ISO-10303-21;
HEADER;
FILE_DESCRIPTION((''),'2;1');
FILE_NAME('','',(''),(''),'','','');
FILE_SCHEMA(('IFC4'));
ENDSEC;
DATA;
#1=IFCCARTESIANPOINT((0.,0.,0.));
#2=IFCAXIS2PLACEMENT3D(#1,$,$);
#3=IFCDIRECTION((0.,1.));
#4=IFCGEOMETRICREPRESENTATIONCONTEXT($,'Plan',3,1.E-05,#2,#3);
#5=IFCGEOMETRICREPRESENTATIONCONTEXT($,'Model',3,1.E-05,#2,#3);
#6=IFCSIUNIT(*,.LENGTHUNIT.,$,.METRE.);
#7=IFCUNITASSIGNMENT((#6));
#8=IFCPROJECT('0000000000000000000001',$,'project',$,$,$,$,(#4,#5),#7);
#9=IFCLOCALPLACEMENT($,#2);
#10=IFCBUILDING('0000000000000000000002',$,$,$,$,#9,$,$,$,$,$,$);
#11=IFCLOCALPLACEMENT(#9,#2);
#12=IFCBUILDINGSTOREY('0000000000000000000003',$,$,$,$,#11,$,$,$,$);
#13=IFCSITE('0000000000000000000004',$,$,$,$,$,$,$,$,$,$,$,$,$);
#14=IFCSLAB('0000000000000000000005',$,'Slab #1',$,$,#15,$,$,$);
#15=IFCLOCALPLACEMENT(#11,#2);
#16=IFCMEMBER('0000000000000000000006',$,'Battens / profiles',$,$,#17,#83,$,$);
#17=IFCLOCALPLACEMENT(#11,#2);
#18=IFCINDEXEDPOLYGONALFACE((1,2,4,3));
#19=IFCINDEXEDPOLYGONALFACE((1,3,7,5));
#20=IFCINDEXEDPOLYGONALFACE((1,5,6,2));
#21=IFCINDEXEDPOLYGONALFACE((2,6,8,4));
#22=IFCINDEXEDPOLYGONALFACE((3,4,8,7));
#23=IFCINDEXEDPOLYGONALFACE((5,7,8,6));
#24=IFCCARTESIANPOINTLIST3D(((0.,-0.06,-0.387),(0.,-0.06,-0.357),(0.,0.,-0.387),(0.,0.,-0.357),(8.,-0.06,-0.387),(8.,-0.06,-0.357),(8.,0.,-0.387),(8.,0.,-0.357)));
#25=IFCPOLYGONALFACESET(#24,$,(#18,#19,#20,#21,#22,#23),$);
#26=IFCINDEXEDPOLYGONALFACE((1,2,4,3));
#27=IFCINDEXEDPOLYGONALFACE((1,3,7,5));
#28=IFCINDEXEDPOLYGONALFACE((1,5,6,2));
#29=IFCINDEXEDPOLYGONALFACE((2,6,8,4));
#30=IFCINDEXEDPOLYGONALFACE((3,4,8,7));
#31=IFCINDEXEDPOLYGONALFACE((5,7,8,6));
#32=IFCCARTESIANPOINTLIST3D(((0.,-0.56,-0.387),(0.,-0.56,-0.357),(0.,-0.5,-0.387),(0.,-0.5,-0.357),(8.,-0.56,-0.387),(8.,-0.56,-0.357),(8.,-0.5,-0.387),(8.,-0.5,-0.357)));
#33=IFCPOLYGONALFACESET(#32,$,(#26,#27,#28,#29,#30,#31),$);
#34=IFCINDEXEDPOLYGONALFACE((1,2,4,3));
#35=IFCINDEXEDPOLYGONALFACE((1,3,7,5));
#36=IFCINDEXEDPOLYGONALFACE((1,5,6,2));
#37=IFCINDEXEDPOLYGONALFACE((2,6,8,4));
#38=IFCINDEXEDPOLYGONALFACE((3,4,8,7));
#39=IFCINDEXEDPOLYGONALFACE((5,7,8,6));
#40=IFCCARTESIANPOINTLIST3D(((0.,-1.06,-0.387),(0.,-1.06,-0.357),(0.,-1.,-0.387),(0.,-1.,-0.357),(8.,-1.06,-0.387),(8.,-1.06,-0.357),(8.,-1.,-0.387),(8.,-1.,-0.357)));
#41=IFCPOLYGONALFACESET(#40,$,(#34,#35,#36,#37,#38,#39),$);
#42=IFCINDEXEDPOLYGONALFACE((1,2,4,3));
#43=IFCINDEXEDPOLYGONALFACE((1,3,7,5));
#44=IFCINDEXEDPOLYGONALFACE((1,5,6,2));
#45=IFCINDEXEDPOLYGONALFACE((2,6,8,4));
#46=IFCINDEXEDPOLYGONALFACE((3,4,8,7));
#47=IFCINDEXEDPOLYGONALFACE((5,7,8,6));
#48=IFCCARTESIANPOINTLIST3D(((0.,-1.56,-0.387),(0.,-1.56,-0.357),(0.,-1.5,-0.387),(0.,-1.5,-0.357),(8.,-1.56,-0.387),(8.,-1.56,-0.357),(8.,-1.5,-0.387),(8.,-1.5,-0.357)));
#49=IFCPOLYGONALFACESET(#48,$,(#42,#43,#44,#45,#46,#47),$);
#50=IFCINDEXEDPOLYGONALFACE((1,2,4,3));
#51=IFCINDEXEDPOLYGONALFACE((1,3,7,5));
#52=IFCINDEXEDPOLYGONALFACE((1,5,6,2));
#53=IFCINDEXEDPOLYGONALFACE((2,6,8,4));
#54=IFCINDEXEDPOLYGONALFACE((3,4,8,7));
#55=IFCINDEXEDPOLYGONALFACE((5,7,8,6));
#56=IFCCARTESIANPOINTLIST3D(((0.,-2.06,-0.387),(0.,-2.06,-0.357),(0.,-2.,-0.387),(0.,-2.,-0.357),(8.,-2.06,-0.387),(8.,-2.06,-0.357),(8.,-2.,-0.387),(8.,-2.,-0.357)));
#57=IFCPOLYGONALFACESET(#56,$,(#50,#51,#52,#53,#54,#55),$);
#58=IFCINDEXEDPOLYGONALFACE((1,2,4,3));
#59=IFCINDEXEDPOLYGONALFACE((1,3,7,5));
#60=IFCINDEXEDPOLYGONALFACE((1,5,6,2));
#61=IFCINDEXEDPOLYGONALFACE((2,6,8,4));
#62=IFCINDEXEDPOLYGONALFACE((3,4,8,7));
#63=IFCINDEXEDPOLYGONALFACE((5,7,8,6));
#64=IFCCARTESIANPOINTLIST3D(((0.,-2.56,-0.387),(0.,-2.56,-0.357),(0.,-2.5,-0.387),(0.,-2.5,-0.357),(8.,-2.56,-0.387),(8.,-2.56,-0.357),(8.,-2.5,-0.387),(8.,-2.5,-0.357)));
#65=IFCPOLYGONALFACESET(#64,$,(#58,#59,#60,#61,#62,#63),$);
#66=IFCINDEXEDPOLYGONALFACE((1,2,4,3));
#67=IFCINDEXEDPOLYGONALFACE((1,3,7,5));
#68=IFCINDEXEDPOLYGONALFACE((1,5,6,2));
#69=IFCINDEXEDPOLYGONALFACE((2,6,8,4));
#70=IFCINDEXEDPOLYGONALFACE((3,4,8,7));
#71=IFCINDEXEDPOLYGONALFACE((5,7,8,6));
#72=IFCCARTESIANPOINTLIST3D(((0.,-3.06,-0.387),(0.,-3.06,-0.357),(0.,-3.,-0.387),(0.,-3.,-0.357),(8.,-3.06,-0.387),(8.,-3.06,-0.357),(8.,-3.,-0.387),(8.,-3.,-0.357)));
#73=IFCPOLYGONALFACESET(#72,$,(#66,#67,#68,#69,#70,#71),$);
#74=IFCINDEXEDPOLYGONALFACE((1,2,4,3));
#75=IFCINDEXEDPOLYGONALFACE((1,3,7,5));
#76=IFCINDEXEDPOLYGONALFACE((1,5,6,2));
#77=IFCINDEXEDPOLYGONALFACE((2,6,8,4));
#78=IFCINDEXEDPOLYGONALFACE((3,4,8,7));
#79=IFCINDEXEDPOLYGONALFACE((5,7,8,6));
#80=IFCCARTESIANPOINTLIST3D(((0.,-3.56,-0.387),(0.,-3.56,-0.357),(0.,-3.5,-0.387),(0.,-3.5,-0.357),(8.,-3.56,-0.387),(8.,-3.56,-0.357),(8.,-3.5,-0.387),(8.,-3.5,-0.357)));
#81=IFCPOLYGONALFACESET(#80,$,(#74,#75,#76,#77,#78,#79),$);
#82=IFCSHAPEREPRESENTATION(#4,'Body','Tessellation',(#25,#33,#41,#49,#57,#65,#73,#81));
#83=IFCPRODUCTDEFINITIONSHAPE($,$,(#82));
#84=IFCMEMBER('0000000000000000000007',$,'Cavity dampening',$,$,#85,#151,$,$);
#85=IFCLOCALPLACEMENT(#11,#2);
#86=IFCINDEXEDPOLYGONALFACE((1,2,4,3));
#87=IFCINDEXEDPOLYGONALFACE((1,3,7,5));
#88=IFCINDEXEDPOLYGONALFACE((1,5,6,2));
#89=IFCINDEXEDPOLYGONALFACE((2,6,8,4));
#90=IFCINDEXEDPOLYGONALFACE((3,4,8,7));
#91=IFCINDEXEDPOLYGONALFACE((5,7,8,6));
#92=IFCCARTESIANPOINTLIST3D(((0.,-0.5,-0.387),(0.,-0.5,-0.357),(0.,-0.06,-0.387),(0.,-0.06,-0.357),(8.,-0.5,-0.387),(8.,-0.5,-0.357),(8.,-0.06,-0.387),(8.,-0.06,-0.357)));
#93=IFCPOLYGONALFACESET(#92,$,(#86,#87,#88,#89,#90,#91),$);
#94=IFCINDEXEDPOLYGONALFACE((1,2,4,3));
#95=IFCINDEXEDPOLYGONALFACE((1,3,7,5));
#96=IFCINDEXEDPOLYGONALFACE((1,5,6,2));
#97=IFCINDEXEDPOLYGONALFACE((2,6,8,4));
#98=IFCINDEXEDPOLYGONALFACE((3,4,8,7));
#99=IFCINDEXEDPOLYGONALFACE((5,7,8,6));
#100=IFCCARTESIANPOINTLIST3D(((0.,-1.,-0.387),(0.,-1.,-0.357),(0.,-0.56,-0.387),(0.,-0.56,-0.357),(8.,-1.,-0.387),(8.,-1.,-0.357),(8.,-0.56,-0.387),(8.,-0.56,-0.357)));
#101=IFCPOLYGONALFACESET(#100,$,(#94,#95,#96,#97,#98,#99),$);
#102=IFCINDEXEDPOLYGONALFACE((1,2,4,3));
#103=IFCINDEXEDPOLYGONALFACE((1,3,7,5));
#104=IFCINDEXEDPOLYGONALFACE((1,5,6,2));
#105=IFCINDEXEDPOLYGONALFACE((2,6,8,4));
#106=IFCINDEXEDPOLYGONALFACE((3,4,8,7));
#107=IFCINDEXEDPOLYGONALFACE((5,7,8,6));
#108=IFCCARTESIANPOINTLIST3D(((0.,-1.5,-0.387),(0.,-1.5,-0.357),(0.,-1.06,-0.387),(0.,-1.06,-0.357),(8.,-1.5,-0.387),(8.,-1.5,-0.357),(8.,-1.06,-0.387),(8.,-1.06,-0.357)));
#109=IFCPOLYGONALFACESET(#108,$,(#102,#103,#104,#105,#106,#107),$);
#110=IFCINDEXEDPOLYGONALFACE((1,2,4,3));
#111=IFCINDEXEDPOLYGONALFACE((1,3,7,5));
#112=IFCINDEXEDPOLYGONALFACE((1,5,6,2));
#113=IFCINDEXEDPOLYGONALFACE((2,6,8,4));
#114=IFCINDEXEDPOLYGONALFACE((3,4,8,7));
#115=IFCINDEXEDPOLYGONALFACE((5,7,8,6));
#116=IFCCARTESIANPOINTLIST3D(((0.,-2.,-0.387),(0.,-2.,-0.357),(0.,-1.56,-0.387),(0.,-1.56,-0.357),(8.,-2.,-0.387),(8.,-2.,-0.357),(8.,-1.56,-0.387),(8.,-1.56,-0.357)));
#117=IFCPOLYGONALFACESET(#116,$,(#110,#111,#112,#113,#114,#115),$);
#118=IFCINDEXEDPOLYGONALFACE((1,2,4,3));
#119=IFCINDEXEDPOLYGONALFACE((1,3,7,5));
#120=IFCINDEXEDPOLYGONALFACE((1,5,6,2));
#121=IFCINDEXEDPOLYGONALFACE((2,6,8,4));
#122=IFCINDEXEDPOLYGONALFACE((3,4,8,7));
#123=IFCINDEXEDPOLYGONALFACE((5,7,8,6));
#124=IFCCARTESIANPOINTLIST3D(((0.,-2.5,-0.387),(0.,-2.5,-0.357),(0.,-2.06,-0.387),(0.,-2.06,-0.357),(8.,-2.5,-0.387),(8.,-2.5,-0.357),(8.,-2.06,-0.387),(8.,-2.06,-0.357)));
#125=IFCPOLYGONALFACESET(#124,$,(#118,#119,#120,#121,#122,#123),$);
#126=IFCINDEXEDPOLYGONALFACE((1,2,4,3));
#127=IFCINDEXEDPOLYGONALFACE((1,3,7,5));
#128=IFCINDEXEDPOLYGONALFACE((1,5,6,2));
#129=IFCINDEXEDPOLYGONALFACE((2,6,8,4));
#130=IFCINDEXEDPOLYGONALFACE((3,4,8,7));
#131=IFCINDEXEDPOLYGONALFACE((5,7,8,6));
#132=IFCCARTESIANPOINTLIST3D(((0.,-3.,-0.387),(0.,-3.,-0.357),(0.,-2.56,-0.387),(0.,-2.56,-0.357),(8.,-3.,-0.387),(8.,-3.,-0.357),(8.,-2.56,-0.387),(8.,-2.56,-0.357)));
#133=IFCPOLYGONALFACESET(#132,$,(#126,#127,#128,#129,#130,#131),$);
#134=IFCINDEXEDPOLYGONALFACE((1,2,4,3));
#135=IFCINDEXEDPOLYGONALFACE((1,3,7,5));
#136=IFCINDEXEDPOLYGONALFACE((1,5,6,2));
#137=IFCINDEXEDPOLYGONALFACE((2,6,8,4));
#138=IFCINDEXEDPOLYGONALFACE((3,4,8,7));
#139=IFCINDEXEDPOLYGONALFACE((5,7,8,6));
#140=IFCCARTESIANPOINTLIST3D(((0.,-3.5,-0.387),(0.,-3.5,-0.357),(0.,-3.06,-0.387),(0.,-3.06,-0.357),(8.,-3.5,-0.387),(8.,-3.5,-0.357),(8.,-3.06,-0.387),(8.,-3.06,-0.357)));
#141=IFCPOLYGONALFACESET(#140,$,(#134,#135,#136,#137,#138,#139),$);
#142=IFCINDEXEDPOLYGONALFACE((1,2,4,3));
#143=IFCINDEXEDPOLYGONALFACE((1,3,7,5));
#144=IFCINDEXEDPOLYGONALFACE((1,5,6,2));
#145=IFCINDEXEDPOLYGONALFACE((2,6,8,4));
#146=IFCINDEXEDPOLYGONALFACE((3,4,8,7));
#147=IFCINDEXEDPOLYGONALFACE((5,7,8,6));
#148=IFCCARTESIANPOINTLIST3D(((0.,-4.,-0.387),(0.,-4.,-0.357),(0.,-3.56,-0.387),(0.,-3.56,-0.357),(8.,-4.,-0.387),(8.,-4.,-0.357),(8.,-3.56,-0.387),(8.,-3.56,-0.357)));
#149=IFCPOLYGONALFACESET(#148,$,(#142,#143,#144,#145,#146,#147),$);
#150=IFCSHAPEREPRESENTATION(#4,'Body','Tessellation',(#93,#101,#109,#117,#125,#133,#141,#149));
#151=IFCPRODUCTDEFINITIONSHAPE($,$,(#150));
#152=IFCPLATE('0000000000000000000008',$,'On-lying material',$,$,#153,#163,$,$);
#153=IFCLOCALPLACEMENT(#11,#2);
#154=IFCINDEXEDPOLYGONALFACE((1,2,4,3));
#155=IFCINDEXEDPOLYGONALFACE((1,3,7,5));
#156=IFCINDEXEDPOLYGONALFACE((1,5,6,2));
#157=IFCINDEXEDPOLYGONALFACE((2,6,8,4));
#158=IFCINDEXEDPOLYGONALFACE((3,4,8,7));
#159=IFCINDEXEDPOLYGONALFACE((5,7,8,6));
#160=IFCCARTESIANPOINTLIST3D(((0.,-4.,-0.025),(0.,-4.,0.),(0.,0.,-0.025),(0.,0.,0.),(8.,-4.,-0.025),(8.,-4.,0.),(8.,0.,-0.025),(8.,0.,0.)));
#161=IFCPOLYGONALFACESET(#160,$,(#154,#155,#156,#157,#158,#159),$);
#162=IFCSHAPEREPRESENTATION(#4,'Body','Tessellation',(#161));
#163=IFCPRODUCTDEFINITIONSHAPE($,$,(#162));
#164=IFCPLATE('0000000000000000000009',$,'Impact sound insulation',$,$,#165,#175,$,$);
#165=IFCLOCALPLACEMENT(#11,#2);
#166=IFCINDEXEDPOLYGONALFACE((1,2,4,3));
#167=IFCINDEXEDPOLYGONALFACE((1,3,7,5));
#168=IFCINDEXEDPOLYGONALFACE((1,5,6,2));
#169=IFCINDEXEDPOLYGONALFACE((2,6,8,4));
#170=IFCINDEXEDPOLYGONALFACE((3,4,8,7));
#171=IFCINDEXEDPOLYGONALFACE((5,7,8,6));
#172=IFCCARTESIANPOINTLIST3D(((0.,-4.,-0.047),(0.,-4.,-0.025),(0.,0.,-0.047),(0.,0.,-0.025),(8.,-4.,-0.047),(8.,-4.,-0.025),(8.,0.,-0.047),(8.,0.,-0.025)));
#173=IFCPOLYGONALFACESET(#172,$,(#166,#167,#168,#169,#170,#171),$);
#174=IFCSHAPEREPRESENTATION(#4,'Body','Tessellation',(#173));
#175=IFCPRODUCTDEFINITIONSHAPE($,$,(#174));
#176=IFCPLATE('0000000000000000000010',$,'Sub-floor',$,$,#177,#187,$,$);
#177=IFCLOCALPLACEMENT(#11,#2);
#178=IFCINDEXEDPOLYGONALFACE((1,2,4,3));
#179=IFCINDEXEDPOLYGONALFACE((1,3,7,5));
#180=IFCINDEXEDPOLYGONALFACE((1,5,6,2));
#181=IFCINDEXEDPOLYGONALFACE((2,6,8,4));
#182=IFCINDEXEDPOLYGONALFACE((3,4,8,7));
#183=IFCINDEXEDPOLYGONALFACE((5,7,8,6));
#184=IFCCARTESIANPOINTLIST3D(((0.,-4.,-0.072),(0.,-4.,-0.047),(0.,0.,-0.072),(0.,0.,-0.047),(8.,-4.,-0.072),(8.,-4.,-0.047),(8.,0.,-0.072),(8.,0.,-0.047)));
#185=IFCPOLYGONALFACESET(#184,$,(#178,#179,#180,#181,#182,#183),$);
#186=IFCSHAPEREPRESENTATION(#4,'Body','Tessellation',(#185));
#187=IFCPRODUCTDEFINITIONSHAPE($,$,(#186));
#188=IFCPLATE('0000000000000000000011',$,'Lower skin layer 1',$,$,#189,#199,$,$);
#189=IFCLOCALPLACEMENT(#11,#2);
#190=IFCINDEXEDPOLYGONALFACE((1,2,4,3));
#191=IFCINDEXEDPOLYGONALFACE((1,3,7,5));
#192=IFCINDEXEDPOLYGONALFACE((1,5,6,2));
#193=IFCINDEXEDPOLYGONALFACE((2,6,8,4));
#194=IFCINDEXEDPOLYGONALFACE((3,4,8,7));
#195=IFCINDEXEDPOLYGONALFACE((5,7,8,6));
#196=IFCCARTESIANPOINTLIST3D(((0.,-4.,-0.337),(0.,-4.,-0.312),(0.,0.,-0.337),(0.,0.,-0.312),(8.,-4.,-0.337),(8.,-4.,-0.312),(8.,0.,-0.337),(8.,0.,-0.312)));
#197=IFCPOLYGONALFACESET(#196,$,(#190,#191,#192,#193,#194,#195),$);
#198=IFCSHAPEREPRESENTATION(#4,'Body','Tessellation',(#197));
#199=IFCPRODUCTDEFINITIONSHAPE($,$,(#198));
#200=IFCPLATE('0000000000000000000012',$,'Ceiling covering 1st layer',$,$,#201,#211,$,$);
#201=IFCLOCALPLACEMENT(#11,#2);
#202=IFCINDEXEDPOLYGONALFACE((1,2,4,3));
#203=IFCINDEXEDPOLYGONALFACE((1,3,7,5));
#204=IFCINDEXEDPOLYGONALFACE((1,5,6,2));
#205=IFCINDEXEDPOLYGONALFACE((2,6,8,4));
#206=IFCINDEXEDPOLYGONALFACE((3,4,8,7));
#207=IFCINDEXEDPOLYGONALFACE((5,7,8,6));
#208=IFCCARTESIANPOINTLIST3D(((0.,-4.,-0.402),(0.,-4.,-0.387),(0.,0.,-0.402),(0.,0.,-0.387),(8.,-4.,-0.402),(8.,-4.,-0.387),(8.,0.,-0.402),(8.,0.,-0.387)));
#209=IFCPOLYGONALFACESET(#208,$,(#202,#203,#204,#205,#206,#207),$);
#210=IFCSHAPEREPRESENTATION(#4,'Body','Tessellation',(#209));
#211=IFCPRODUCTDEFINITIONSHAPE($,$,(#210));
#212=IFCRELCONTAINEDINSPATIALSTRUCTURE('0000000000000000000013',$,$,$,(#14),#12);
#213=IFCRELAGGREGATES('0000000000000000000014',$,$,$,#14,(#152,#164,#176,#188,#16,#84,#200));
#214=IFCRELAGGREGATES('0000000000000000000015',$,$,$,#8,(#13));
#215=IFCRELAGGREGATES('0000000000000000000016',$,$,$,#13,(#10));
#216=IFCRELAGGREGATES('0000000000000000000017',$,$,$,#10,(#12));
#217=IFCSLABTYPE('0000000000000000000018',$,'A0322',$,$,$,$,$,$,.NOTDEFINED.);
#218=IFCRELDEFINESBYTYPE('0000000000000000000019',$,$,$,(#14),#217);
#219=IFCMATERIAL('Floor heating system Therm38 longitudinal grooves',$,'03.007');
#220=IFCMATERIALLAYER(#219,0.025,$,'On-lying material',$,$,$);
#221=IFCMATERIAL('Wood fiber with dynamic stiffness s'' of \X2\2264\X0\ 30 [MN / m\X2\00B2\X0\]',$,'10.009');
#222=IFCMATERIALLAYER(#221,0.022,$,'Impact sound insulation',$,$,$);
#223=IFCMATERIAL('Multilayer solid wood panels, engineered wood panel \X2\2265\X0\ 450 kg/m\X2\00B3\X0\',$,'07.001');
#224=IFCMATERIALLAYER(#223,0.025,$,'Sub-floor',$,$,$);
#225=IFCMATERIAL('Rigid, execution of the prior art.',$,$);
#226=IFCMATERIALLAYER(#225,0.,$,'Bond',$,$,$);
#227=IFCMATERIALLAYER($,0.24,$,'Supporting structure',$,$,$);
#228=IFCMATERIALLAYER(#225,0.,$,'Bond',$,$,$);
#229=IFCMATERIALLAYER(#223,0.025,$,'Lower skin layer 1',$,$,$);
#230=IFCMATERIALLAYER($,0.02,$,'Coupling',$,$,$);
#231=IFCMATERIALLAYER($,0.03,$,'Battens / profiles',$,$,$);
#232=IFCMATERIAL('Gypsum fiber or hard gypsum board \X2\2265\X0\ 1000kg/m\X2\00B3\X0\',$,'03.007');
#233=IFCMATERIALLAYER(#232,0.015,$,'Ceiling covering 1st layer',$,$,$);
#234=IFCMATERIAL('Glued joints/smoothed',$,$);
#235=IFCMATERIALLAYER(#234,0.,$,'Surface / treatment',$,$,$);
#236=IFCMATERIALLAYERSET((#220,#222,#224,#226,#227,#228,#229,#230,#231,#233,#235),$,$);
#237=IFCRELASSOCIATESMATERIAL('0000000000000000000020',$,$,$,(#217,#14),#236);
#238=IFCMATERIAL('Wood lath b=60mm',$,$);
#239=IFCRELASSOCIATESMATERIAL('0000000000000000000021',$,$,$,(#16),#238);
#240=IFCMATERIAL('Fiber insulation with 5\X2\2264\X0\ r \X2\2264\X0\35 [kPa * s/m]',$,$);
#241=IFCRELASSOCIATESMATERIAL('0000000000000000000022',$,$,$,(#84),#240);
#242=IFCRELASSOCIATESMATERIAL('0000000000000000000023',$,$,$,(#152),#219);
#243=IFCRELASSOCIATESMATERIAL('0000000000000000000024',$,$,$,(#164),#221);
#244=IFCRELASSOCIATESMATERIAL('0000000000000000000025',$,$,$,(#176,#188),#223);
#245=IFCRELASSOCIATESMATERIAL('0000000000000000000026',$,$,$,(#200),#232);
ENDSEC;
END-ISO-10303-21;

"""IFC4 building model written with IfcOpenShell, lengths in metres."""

from ifc_helpers import new_model, si_unit, direction, frame, frame_2d, origin, origin_with_axes, place, context, project, spatial, rectangle, extrude, material, layer, layer_set, type_object, element, aggregate, save


model = new_model("IFC4")

# Units and contexts
plan_context = context("Plan", 3, precision=1e-05, world=origin(), true_north=direction((0.0, 1.0)))
model_context = context("Model", 3, precision=1e-05, world=origin(), true_north=direction((0.0, 1.0)))
ifc_project = project(units=[si_unit("LENGTHUNIT", "METRE")], contexts=[plan_context, model_context])

# Site, building, storey
site = spatial("IfcSite", under=ifc_project)
building_placement = place(None, origin())
building = spatial("IfcBuilding", under=site, at=building_placement)
storey_placement = place(building_placement, origin())
storey = spatial("IfcBuildingStorey", under=building, at=storey_placement)

# Slab, members, plates
ifc_material_1 = material(Name="Floor heating system Therm38 longitudinal grooves", Category="03.007")
ifc_layer_1 = layer(ifc_material_1, 0.025, Name="On-lying material")
ifc_material_2 = material(Name="Wood fiber with dynamic stiffness s' of ≤ 30 [MN / m²]", Category="10.009")
ifc_layer_2 = layer(ifc_material_2, 0.022, Name="Impact sound insulation")
ifc_material_3 = material(Name="Multilayer solid wood panels, engineered wood panel ≥ 450 kg/m³", Category="07.001")
ifc_layer_3 = layer(ifc_material_3, 0.025, Name="Sub-floor")
ifc_material_4 = material(Name="Rigid, execution of the prior art.")
ifc_layer_4 = layer(ifc_material_4, 0.0, Name="Bond")
ifc_layer_5 = layer(None, 0.24, Name="Supporting structure")
ifc_layer_6 = layer(ifc_material_4, 0.0, Name="Bond")
ifc_layer_7 = layer(ifc_material_3, 0.025, Name="Lower skin layer 1")
ifc_layer_8 = layer(None, 0.02, Name="Coupling")
ifc_layer_9 = layer(None, 0.03, Name="Battens / profiles")
ifc_material_5 = material(Name="Gypsum fiber or hard gypsum board ≥ 1000kg/m³", Category="03.007")
ifc_layer_10 = layer(ifc_material_5, 0.015, Name="Ceiling covering 1st layer")
ifc_material_6 = material(Name="Glued joints/smoothed")
ifc_layer_11 = layer(ifc_material_6, 0.0, Name="Surface / treatment")
ifc_layer_set = layer_set([ifc_layer_1, ifc_layer_2, ifc_layer_3, ifc_layer_4, ifc_layer_5, ifc_layer_6, ifc_layer_7, ifc_layer_8, ifc_layer_9, ifc_layer_10, ifc_layer_11])
slab_type = type_object("IfcSlabType", Name="A0322", PredefinedType="NOTDEFINED", material=ifc_layer_set)
slab_placement = place(None, frame((0.0, 0.0, 0.0), z_axis=(0.0, 0.0, -1.0), x_axis=(1.0, 0.0, 0.0)))
slab = element("IfcSlab", 1, at=slab_placement, inside=storey, type_object=slab_type, material=ifc_layer_set, Name="Slab #1")
ifc_material_7 = material(Name="Fiber insulation with 5≤ r ≤35 [kPa * s/m]")
ifc_material_8 = material(Name="Wood lath b=60mm")
member_1_placement = place(slab_placement, origin())
member_1 = element("IfcMember", 2, at=member_1_placement, material=ifc_material_8, Name="Battens / profiles", context=plan_context, shape_type="SweptSolid", body=[
    extrude(rectangle(XDim=0.06, YDim=0.03, at=frame_2d((0.03, 0.015), x_axis=(1.0, 0.0))), frame((0.0, 0.0, 0.357), z_axis=(1.0, 0.0, 0.0), x_axis=(0.0, 1.0, 0.0)), (0.0, 0.0, 1.0), 8.0),
    extrude(rectangle(XDim=0.06, YDim=0.03, at=frame_2d((0.03, 0.015), x_axis=(1.0, 0.0))), frame((0.0, 0.5, 0.357), z_axis=(1.0, 0.0, 0.0), x_axis=(0.0, 1.0, 0.0)), (0.0, 0.0, 1.0), 8.0),
    extrude(rectangle(XDim=0.06, YDim=0.03, at=frame_2d((0.03, 0.015), x_axis=(1.0, 0.0))), frame((0.0, 1.0, 0.357), z_axis=(1.0, 0.0, 0.0), x_axis=(0.0, 1.0, 0.0)), (0.0, 0.0, 1.0), 8.0),
    extrude(rectangle(XDim=0.06, YDim=0.03, at=frame_2d((0.03, 0.015), x_axis=(1.0, 0.0))), frame((0.0, 1.5, 0.357), z_axis=(1.0, 0.0, 0.0), x_axis=(0.0, 1.0, 0.0)), (0.0, 0.0, 1.0), 8.0),
    extrude(rectangle(XDim=0.06, YDim=0.03, at=frame_2d((0.03, 0.015), x_axis=(1.0, 0.0))), frame((0.0, 2.0, 0.357), z_axis=(1.0, 0.0, 0.0), x_axis=(0.0, 1.0, 0.0)), (0.0, 0.0, 1.0), 8.0),
    extrude(rectangle(XDim=0.06, YDim=0.03, at=frame_2d((0.03, 0.015), x_axis=(1.0, 0.0))), frame((0.0, 2.5, 0.357), z_axis=(1.0, 0.0, 0.0), x_axis=(0.0, 1.0, 0.0)), (0.0, 0.0, 1.0), 8.0),
    extrude(rectangle(XDim=0.06, YDim=0.03, at=frame_2d((0.03, 0.015), x_axis=(1.0, 0.0))), frame((0.0, 3.0, 0.357), z_axis=(1.0, 0.0, 0.0), x_axis=(0.0, 1.0, 0.0)), (0.0, 0.0, 1.0), 8.0),
    extrude(rectangle(XDim=0.06, YDim=0.03, at=frame_2d((0.03, 0.015), x_axis=(1.0, 0.0))), frame((0.0, 3.5, 0.357), z_axis=(1.0, 0.0, 0.0), x_axis=(0.0, 1.0, 0.0)), (0.0, 0.0, 1.0), 8.0),
])
member_2_placement = place(slab_placement, origin())
member_2 = element("IfcMember", 3, at=member_2_placement, material=ifc_material_7, Name="Cavity dampening", context=plan_context, shape_type="SweptSolid", body=[
    extrude(rectangle(XDim=0.44, YDim=0.03, at=frame_2d((0.22, 0.015), x_axis=(1.0, 0.0))), frame((0.0, 0.06, 0.357), z_axis=(1.0, 0.0, 0.0), x_axis=(0.0, 1.0, 0.0)), (0.0, 0.0, 1.0), 8.0),
    extrude(rectangle(XDim=0.44, YDim=0.03, at=frame_2d((0.22, 0.015), x_axis=(1.0, 0.0))), frame((0.0, 0.56, 0.357), z_axis=(1.0, 0.0, 0.0), x_axis=(0.0, 1.0, 0.0)), (0.0, 0.0, 1.0), 8.0),
    extrude(rectangle(XDim=0.44, YDim=0.03, at=frame_2d((0.22, 0.015), x_axis=(1.0, 0.0))), frame((0.0, 1.06, 0.357), z_axis=(1.0, 0.0, 0.0), x_axis=(0.0, 1.0, 0.0)), (0.0, 0.0, 1.0), 8.0),
    extrude(rectangle(XDim=0.44, YDim=0.03, at=frame_2d((0.22, 0.015), x_axis=(1.0, 0.0))), frame((0.0, 1.56, 0.357), z_axis=(1.0, 0.0, 0.0), x_axis=(0.0, 1.0, 0.0)), (0.0, 0.0, 1.0), 8.0),
    extrude(rectangle(XDim=0.44, YDim=0.03, at=frame_2d((0.22, 0.015), x_axis=(1.0, 0.0))), frame((0.0, 2.06, 0.357), z_axis=(1.0, 0.0, 0.0), x_axis=(0.0, 1.0, 0.0)), (0.0, 0.0, 1.0), 8.0),
    extrude(rectangle(XDim=0.44, YDim=0.03, at=frame_2d((0.22, 0.015), x_axis=(1.0, 0.0))), frame((0.0, 2.56, 0.357), z_axis=(1.0, 0.0, 0.0), x_axis=(0.0, 1.0, 0.0)), (0.0, 0.0, 1.0), 8.0),
    extrude(rectangle(XDim=0.44, YDim=0.03, at=frame_2d((0.22, 0.015), x_axis=(1.0, 0.0))), frame((0.0, 3.06, 0.357), z_axis=(1.0, 0.0, 0.0), x_axis=(0.0, 1.0, 0.0)), (0.0, 0.0, 1.0), 8.0),
    extrude(rectangle(XDim=0.44, YDim=0.03, at=frame_2d((0.22, 0.015), x_axis=(1.0, 0.0))), frame((0.0, 3.56, 0.357), z_axis=(1.0, 0.0, 0.0), x_axis=(0.0, 1.0, 0.0)), (0.0, 0.0, 1.0), 8.0),
])
plate_1_placement = place(slab_placement, origin())
plate_1 = element("IfcPlate", 4, at=plate_1_placement, material=ifc_material_1, Name="On-lying material", context=plan_context, shape_type="SweptSolid", body=[
    extrude(rectangle(XDim=8.0, YDim=4.0, at=frame_2d((4.0, 2.0), x_axis=(1.0, 0.0))), origin_with_axes(), (0.0, 0.0, 1.0), 0.025),
])
plate_2_placement = place(slab_placement, origin())
plate_2 = element("IfcPlate", 5, at=plate_2_placement, material=ifc_material_2, Name="Impact sound insulation", context=plan_context, shape_type="SweptSolid", body=[
    extrude(rectangle(XDim=8.0, YDim=4.0, at=frame_2d((4.0, 2.0), x_axis=(1.0, 0.0))), frame((0.0, 0.0, 0.025), z_axis=(0.0, 0.0, 1.0), x_axis=(1.0, 0.0, 0.0)), (0.0, 0.0, 1.0), 0.022),
])
plate_3_placement = place(slab_placement, origin())
plate_3 = element("IfcPlate", 6, at=plate_3_placement, material=ifc_material_3, Name="Sub-floor", context=plan_context, shape_type="SweptSolid", body=[
    extrude(rectangle(XDim=8.0, YDim=4.0, at=frame_2d((4.0, 2.0), x_axis=(1.0, 0.0))), frame((0.0, 0.0, 0.047), z_axis=(0.0, 0.0, 1.0), x_axis=(1.0, 0.0, 0.0)), (0.0, 0.0, 1.0), 0.025),
])
plate_4_placement = place(slab_placement, origin())
plate_4 = element("IfcPlate", 7, at=plate_4_placement, material=ifc_material_3, Name="Lower skin layer 1", context=plan_context, shape_type="SweptSolid", body=[
    extrude(rectangle(XDim=8.0, YDim=4.0, at=frame_2d((4.0, 2.0), x_axis=(1.0, 0.0))), frame((0.0, 0.0, 0.312), z_axis=(0.0, 0.0, 1.0), x_axis=(1.0, 0.0, 0.0)), (0.0, 0.0, 1.0), 0.025),
])
plate_5_placement = place(slab_placement, origin())
plate_5 = element("IfcPlate", 8, at=plate_5_placement, material=ifc_material_5, Name="Ceiling covering 1st layer", context=plan_context, shape_type="SweptSolid", body=[
    extrude(rectangle(XDim=8.0, YDim=4.0, at=frame_2d((4.0, 2.0), x_axis=(1.0, 0.0))), frame((0.0, 0.0, 0.387), z_axis=(0.0, 0.0, 1.0), x_axis=(1.0, 0.0, 0.0)), (0.0, 0.0, 1.0), 0.015),
])
aggregate(slab, [plate_1, plate_2, plate_3, plate_4, member_1, member_2, plate_5])

save(model, "model.ifc")
